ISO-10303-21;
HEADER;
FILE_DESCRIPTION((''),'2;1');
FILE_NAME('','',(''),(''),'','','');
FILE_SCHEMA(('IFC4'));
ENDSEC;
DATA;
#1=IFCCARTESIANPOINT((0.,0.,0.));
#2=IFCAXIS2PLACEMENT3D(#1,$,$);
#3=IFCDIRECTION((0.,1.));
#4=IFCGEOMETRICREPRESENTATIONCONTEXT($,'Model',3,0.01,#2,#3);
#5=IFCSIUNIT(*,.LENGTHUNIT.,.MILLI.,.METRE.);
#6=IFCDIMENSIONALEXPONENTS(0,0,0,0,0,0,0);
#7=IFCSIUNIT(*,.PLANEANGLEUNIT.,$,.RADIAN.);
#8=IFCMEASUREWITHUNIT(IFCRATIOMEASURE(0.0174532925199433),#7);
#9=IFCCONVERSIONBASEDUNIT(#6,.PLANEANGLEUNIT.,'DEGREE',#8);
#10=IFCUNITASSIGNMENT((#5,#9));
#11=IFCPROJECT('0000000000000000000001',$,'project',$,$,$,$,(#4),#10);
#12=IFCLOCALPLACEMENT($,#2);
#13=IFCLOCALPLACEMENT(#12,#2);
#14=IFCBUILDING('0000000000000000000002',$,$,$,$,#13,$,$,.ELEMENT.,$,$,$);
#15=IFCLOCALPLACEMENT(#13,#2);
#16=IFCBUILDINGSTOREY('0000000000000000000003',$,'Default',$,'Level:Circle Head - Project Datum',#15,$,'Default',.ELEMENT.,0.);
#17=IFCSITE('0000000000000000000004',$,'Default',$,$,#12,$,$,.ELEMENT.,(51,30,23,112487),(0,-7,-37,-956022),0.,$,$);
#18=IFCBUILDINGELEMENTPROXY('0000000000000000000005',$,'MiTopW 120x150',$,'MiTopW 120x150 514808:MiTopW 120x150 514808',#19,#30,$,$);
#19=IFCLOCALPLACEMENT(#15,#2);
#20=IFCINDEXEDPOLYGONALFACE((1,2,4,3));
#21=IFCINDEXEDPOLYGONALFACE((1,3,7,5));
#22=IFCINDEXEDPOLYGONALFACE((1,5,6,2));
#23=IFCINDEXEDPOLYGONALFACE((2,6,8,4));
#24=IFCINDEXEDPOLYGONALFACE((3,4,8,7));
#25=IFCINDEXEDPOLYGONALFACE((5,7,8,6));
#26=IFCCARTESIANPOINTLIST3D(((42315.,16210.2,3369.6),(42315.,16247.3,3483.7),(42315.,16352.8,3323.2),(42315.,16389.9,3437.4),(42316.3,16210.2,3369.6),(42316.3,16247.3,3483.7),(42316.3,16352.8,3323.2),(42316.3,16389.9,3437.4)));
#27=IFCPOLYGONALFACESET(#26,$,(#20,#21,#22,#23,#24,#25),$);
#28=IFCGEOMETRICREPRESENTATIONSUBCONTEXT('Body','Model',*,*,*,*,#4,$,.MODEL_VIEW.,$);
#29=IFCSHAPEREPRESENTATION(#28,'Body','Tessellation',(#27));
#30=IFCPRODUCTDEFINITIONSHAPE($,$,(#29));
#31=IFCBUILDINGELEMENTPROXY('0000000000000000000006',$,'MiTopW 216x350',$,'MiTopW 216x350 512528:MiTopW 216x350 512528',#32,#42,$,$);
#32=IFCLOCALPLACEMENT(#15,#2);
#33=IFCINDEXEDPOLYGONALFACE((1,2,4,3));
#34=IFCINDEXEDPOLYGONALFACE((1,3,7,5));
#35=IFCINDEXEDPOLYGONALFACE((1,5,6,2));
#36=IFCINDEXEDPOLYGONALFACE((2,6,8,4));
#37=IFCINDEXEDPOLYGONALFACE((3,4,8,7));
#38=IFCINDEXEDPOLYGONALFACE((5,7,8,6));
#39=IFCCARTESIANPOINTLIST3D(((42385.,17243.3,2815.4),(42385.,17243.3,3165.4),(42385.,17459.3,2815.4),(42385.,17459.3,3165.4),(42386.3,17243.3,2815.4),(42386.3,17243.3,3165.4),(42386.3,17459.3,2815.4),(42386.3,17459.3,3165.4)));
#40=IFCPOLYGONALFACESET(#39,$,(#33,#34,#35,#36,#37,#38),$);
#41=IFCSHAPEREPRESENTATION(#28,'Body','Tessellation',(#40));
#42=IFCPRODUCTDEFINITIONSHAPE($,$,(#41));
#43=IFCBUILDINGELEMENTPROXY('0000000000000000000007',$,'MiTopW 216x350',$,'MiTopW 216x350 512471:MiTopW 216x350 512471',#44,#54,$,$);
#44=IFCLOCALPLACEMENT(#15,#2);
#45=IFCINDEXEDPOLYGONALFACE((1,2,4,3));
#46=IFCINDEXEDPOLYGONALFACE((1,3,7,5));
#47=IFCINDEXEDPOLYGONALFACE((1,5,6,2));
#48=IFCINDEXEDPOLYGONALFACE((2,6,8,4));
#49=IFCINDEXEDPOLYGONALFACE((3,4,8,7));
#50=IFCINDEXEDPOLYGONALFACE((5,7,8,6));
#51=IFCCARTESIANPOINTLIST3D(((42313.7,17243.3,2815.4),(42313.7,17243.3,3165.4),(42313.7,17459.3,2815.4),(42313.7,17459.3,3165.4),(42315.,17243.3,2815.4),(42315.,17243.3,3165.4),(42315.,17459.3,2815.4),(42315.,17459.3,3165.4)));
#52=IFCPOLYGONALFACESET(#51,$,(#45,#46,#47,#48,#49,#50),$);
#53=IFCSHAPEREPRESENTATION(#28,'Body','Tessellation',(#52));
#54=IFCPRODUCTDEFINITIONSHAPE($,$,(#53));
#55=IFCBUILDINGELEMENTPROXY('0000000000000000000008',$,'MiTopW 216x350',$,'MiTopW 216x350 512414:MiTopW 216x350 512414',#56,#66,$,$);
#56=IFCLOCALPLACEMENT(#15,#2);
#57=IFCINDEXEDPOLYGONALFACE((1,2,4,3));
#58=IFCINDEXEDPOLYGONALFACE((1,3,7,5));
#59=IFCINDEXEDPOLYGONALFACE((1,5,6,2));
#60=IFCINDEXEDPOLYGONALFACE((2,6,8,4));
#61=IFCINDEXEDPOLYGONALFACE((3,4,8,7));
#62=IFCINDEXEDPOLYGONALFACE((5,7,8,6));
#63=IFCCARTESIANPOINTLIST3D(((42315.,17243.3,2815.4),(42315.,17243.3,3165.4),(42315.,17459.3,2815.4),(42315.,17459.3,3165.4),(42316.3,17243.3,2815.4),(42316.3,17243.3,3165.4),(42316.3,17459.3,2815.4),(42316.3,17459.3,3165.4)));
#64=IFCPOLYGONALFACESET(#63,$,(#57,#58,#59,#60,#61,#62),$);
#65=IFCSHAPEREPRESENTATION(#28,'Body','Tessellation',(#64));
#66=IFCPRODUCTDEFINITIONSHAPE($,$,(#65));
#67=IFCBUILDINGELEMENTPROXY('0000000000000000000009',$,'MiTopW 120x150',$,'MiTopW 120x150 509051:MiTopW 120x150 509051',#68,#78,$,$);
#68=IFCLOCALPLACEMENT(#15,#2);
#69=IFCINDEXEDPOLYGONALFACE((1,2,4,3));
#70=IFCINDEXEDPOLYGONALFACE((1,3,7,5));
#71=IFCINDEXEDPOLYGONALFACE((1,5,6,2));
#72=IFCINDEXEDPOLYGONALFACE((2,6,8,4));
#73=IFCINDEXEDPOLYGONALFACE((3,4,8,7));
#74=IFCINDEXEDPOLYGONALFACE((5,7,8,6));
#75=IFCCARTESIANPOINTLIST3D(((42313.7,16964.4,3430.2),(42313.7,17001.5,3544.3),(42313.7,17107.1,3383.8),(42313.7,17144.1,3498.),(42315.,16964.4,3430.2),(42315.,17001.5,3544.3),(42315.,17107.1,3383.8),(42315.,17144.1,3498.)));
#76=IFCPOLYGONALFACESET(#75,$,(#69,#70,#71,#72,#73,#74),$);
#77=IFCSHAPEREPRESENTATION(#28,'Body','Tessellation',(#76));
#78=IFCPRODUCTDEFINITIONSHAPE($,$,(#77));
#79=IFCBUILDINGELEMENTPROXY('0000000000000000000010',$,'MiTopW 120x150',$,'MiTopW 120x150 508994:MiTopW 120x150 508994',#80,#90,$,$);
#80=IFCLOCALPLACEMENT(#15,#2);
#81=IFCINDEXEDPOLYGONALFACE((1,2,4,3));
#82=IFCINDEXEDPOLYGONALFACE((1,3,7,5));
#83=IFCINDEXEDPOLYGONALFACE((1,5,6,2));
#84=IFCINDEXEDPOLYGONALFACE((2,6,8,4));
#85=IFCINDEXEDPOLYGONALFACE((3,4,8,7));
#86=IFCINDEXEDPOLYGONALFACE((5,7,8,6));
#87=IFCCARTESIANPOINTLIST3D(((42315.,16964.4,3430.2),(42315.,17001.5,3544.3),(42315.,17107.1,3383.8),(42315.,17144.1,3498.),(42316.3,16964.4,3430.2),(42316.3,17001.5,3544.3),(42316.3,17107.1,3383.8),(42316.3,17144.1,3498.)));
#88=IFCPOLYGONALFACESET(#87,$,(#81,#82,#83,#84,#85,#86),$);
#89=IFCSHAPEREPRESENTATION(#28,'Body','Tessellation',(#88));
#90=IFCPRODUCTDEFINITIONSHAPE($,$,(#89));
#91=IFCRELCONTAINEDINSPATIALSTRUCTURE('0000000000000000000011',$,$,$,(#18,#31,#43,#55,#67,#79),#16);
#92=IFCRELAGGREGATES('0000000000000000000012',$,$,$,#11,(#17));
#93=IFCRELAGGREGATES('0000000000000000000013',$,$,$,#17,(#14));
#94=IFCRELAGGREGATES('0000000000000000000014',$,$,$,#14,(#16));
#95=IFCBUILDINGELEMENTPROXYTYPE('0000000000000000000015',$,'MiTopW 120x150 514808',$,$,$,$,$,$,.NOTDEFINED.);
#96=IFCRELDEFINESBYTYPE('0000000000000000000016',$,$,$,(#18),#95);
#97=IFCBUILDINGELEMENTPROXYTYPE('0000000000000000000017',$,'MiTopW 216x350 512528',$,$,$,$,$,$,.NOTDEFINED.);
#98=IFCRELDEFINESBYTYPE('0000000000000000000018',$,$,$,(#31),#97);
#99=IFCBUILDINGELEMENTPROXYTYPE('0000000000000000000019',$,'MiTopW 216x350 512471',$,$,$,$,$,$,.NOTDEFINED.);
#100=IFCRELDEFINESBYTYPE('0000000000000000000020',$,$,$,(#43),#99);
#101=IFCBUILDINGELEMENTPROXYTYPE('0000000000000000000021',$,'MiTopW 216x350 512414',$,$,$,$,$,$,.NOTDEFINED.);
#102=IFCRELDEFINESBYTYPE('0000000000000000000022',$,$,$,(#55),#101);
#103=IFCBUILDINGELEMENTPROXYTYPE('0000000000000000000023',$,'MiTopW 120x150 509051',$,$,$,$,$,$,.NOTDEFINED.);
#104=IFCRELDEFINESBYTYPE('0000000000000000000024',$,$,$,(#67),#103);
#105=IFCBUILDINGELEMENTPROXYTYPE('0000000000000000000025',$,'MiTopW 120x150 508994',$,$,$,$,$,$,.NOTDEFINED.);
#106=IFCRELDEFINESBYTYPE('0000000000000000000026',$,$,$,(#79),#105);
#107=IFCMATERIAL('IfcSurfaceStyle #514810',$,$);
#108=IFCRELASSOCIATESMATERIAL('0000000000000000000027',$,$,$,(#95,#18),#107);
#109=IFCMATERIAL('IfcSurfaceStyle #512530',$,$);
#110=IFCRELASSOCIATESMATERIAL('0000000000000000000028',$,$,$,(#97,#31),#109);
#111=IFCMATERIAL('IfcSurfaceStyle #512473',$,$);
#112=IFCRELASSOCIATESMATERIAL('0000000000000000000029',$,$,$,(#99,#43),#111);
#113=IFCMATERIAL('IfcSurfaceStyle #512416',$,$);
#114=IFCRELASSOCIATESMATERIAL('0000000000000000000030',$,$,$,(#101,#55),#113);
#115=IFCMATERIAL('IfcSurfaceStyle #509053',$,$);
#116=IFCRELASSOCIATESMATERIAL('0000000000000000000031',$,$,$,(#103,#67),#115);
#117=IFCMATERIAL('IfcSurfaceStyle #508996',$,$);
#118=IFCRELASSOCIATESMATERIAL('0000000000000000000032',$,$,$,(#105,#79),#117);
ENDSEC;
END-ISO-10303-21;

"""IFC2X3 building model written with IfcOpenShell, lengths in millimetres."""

from ifc_helpers import new_model, entity, si_unit, converted_unit, direction, frame, origin, origin_2d_with_axis, place, context, subcontext, project, spatial, polyline, rectangle, outline, extrude, source, transform, mapped, material, type_object, type_shapes, element, save


model = new_model("IFC2X3")

# Units and contexts
model_context = context("Model", 3, precision=0.01, world=origin(), true_north=direction((0.0, 1.0)))
body_context = subcontext(model_context, "Body", "Model", "MODEL_VIEW")
ifc_project = project(units=[si_unit("LENGTHUNIT", "METRE", prefix="MILLI"), converted_unit("PLANEANGLEUNIT", "DEGREE", entity("IfcRatioMeasure", 0.0174532925199433), si_unit("PLANEANGLEUNIT", "RADIAN"), dimensions=[0, 0, 0, 0, 0, 0, 0])], contexts=[model_context])

# Site, building, storey
site_placement = place(None, origin())
site = spatial("IfcSite", under=ifc_project, at=site_placement, Name="Default", CompositionType="ELEMENT", RefLatitude=(51, 30, 23, 112487), RefLongitude=(0, -7, -37, -956022), RefElevation=0.0)
building_placement = place(site_placement, origin())
building = spatial("IfcBuilding", under=site, at=building_placement, CompositionType="ELEMENT")
storey_placement = place(building_placement, origin())
storey = spatial("IfcBuildingStorey", under=building, at=storey_placement, Name="Default", ObjectType="Level:Circle Head - Project Datum", LongName="Default", CompositionType="ELEMENT", Elevation=0.0)

# Building element proxies
ifc_material_1 = material(Name="IfcSurfaceStyle #514810")
building_element_proxy_type_1 = type_object("IfcBuildingElementProxyType", Name="MiTopW 120x150 514808", PredefinedType="NOTDEFINED", material=ifc_material_1)
shared_shape_1 = source(origin(), body_context, "Body", "SweptSolid", [
    extrude(outline(polyline([(-75.0, -60.0), (75.0, -60.0), (75.0, 60.0), (-75.0, 60.0), (-75.0, -60.0)])), frame((75.0, 60.0, 0.0), z_axis=(0.0, 0.0, 1.0), x_axis=(-1.0, 0.0, 0.0)), (0.0, 0.0, 1.0), 1.3),
])
type_shapes(building_element_proxy_type_1, [shared_shape_1])
proxy_1_placement = place(building_placement, frame((42316.3, 16352.8, 3323.2), z_axis=(-1.0, 0.0, 0.0), x_axis=(0.0, -0.951057, 0.309017)))
element("IfcBuildingElementProxy", 1, at=proxy_1_placement, inside=storey, type_object=building_element_proxy_type_1, material=ifc_material_1, Name="MiTopW 120x150", ObjectType="MiTopW 120x150 514808:MiTopW 120x150 514808", context=body_context, shape_type="MappedRepresentation", body=[
    mapped(shared_shape_1, transform((0.0, 0.0, 0.0), scale=1.0)),
])
ifc_material_2 = material(Name="IfcSurfaceStyle #512530")
building_element_proxy_type_2 = type_object("IfcBuildingElementProxyType", Name="MiTopW 216x350 512528", PredefinedType="NOTDEFINED", material=ifc_material_2)
shared_shape_2 = source(origin(), body_context, "Body", "SweptSolid", [
    extrude(rectangle(XDim=350.0, YDim=216.0, at=origin_2d_with_axis()), frame((175.0, 108.0, 0.0), z_axis=(0.0, 0.0, 1.0), x_axis=(-1.0, 0.0, 0.0)), (0.0, 0.0, 1.0), 1.3),
])
type_shapes(building_element_proxy_type_2, [shared_shape_2])
proxy_2_placement = place(building_placement, frame((42386.3, 17459.3, 3165.4), z_axis=(-1.0, 0.0, 0.0), x_axis=(0.0, 0.0, -1.0)))
element("IfcBuildingElementProxy", 2, at=proxy_2_placement, inside=storey, type_object=building_element_proxy_type_2, material=ifc_material_2, Name="MiTopW 216x350", ObjectType="MiTopW 216x350 512528:MiTopW 216x350 512528", context=body_context, shape_type="MappedRepresentation", body=[
    mapped(shared_shape_2, transform((0.0, 0.0, 0.0), scale=1.0)),
])
ifc_material_3 = material(Name="IfcSurfaceStyle #512473")
building_element_proxy_type_3 = type_object("IfcBuildingElementProxyType", Name="MiTopW 216x350 512471", PredefinedType="NOTDEFINED", material=ifc_material_3)
shared_shape_3 = source(origin(), body_context, "Body", "SweptSolid", [
    extrude(rectangle(XDim=350.0, YDim=216.0, at=origin_2d_with_axis()), frame((175.0, 108.0, 0.0), z_axis=(0.0, 0.0, 1.0), x_axis=(-1.0, 0.0, 0.0)), (0.0, 0.0, 1.0), 1.3),
])
type_shapes(building_element_proxy_type_3, [shared_shape_3])
proxy_3_placement = place(building_placement, frame((42315.0, 17459.3, 3165.4), z_axis=(-1.0, 0.0, 0.0), x_axis=(0.0, 0.0, -1.0)))
element("IfcBuildingElementProxy", 3, at=proxy_3_placement, inside=storey, type_object=building_element_proxy_type_3, material=ifc_material_3, Name="MiTopW 216x350", ObjectType="MiTopW 216x350 512471:MiTopW 216x350 512471", context=body_context, shape_type="MappedRepresentation", body=[
    mapped(shared_shape_3, transform((0.0, 0.0, 0.0), scale=1.0)),
])
ifc_material_4 = material(Name="IfcSurfaceStyle #512416")
building_element_proxy_type_4 = type_object("IfcBuildingElementProxyType", Name="MiTopW 216x350 512414", PredefinedType="NOTDEFINED", material=ifc_material_4)
shared_shape_4 = source(origin(), body_context, "Body", "SweptSolid", [
    extrude(rectangle(XDim=350.0, YDim=216.0, at=origin_2d_with_axis()), frame((175.0, 108.0, 0.0), z_axis=(0.0, 0.0, 1.0), x_axis=(-1.0, 0.0, 0.0)), (0.0, 0.0, 1.0), 1.3),
])
type_shapes(building_element_proxy_type_4, [shared_shape_4])
proxy_4_placement = place(building_placement, frame((42316.3, 17459.3, 3165.4), z_axis=(-1.0, 0.0, 0.0), x_axis=(0.0, 0.0, -1.0)))
element("IfcBuildingElementProxy", 4, at=proxy_4_placement, inside=storey, type_object=building_element_proxy_type_4, material=ifc_material_4, Name="MiTopW 216x350", ObjectType="MiTopW 216x350 512414:MiTopW 216x350 512414", context=body_context, shape_type="MappedRepresentation", body=[
    mapped(shared_shape_4, transform((0.0, 0.0, 0.0), scale=1.0)),
])
ifc_material_5 = material(Name="IfcSurfaceStyle #509053")
building_element_proxy_type_5 = type_object("IfcBuildingElementProxyType", Name="MiTopW 120x150 509051", PredefinedType="NOTDEFINED", material=ifc_material_5)
shared_shape_5 = source(origin(), body_context, "Body", "SweptSolid", [
    extrude(outline(polyline([(-75.0, -60.0), (75.0, -60.0), (75.0, 60.0), (-75.0, 60.0), (-75.0, -60.0)])), frame((75.0, 60.0, 0.0), z_axis=(0.0, 0.0, 1.0), x_axis=(-1.0, 0.0, 0.0)), (0.0, 0.0, 1.0), 1.3),
])
type_shapes(building_element_proxy_type_5, [shared_shape_5])
proxy_5_placement = place(building_placement, frame((42315.0, 17107.1, 3383.8), z_axis=(-1.0, 0.0, 0.0), x_axis=(0.0, -0.951057, 0.309017)))
element("IfcBuildingElementProxy", 5, at=proxy_5_placement, inside=storey, type_object=building_element_proxy_type_5, material=ifc_material_5, Name="MiTopW 120x150", ObjectType="MiTopW 120x150 509051:MiTopW 120x150 509051", context=body_context, shape_type="MappedRepresentation", body=[
    mapped(shared_shape_5, transform((0.0, 0.0, 0.0), scale=1.0)),
])
ifc_material_6 = material(Name="IfcSurfaceStyle #508996")
building_element_proxy_type_6 = type_object("IfcBuildingElementProxyType", Name="MiTopW 120x150 508994", PredefinedType="NOTDEFINED", material=ifc_material_6)
shared_shape_6 = source(origin(), body_context, "Body", "SweptSolid", [
    extrude(outline(polyline([(-75.0, -60.0), (75.0, -60.0), (75.0, 60.0), (-75.0, 60.0), (-75.0, -60.0)])), frame((75.0, 60.0, 0.0), z_axis=(0.0, 0.0, 1.0), x_axis=(-1.0, 0.0, 0.0)), (0.0, 0.0, 1.0), 1.3),
])
type_shapes(building_element_proxy_type_6, [shared_shape_6])
proxy_6_placement = place(building_placement, frame((42316.3, 17107.1, 3383.8), z_axis=(-1.0, 0.0, 0.0), x_axis=(0.0, -0.951057, 0.309017)))
element("IfcBuildingElementProxy", 6, at=proxy_6_placement, inside=storey, type_object=building_element_proxy_type_6, material=ifc_material_6, Name="MiTopW 120x150", ObjectType="MiTopW 120x150 508994:MiTopW 120x150 508994", context=body_context, shape_type="MappedRepresentation", body=[
    mapped(shared_shape_6, transform((0.0, 0.0, 0.0), scale=1.0)),
])

save(model, "model.ifc")
